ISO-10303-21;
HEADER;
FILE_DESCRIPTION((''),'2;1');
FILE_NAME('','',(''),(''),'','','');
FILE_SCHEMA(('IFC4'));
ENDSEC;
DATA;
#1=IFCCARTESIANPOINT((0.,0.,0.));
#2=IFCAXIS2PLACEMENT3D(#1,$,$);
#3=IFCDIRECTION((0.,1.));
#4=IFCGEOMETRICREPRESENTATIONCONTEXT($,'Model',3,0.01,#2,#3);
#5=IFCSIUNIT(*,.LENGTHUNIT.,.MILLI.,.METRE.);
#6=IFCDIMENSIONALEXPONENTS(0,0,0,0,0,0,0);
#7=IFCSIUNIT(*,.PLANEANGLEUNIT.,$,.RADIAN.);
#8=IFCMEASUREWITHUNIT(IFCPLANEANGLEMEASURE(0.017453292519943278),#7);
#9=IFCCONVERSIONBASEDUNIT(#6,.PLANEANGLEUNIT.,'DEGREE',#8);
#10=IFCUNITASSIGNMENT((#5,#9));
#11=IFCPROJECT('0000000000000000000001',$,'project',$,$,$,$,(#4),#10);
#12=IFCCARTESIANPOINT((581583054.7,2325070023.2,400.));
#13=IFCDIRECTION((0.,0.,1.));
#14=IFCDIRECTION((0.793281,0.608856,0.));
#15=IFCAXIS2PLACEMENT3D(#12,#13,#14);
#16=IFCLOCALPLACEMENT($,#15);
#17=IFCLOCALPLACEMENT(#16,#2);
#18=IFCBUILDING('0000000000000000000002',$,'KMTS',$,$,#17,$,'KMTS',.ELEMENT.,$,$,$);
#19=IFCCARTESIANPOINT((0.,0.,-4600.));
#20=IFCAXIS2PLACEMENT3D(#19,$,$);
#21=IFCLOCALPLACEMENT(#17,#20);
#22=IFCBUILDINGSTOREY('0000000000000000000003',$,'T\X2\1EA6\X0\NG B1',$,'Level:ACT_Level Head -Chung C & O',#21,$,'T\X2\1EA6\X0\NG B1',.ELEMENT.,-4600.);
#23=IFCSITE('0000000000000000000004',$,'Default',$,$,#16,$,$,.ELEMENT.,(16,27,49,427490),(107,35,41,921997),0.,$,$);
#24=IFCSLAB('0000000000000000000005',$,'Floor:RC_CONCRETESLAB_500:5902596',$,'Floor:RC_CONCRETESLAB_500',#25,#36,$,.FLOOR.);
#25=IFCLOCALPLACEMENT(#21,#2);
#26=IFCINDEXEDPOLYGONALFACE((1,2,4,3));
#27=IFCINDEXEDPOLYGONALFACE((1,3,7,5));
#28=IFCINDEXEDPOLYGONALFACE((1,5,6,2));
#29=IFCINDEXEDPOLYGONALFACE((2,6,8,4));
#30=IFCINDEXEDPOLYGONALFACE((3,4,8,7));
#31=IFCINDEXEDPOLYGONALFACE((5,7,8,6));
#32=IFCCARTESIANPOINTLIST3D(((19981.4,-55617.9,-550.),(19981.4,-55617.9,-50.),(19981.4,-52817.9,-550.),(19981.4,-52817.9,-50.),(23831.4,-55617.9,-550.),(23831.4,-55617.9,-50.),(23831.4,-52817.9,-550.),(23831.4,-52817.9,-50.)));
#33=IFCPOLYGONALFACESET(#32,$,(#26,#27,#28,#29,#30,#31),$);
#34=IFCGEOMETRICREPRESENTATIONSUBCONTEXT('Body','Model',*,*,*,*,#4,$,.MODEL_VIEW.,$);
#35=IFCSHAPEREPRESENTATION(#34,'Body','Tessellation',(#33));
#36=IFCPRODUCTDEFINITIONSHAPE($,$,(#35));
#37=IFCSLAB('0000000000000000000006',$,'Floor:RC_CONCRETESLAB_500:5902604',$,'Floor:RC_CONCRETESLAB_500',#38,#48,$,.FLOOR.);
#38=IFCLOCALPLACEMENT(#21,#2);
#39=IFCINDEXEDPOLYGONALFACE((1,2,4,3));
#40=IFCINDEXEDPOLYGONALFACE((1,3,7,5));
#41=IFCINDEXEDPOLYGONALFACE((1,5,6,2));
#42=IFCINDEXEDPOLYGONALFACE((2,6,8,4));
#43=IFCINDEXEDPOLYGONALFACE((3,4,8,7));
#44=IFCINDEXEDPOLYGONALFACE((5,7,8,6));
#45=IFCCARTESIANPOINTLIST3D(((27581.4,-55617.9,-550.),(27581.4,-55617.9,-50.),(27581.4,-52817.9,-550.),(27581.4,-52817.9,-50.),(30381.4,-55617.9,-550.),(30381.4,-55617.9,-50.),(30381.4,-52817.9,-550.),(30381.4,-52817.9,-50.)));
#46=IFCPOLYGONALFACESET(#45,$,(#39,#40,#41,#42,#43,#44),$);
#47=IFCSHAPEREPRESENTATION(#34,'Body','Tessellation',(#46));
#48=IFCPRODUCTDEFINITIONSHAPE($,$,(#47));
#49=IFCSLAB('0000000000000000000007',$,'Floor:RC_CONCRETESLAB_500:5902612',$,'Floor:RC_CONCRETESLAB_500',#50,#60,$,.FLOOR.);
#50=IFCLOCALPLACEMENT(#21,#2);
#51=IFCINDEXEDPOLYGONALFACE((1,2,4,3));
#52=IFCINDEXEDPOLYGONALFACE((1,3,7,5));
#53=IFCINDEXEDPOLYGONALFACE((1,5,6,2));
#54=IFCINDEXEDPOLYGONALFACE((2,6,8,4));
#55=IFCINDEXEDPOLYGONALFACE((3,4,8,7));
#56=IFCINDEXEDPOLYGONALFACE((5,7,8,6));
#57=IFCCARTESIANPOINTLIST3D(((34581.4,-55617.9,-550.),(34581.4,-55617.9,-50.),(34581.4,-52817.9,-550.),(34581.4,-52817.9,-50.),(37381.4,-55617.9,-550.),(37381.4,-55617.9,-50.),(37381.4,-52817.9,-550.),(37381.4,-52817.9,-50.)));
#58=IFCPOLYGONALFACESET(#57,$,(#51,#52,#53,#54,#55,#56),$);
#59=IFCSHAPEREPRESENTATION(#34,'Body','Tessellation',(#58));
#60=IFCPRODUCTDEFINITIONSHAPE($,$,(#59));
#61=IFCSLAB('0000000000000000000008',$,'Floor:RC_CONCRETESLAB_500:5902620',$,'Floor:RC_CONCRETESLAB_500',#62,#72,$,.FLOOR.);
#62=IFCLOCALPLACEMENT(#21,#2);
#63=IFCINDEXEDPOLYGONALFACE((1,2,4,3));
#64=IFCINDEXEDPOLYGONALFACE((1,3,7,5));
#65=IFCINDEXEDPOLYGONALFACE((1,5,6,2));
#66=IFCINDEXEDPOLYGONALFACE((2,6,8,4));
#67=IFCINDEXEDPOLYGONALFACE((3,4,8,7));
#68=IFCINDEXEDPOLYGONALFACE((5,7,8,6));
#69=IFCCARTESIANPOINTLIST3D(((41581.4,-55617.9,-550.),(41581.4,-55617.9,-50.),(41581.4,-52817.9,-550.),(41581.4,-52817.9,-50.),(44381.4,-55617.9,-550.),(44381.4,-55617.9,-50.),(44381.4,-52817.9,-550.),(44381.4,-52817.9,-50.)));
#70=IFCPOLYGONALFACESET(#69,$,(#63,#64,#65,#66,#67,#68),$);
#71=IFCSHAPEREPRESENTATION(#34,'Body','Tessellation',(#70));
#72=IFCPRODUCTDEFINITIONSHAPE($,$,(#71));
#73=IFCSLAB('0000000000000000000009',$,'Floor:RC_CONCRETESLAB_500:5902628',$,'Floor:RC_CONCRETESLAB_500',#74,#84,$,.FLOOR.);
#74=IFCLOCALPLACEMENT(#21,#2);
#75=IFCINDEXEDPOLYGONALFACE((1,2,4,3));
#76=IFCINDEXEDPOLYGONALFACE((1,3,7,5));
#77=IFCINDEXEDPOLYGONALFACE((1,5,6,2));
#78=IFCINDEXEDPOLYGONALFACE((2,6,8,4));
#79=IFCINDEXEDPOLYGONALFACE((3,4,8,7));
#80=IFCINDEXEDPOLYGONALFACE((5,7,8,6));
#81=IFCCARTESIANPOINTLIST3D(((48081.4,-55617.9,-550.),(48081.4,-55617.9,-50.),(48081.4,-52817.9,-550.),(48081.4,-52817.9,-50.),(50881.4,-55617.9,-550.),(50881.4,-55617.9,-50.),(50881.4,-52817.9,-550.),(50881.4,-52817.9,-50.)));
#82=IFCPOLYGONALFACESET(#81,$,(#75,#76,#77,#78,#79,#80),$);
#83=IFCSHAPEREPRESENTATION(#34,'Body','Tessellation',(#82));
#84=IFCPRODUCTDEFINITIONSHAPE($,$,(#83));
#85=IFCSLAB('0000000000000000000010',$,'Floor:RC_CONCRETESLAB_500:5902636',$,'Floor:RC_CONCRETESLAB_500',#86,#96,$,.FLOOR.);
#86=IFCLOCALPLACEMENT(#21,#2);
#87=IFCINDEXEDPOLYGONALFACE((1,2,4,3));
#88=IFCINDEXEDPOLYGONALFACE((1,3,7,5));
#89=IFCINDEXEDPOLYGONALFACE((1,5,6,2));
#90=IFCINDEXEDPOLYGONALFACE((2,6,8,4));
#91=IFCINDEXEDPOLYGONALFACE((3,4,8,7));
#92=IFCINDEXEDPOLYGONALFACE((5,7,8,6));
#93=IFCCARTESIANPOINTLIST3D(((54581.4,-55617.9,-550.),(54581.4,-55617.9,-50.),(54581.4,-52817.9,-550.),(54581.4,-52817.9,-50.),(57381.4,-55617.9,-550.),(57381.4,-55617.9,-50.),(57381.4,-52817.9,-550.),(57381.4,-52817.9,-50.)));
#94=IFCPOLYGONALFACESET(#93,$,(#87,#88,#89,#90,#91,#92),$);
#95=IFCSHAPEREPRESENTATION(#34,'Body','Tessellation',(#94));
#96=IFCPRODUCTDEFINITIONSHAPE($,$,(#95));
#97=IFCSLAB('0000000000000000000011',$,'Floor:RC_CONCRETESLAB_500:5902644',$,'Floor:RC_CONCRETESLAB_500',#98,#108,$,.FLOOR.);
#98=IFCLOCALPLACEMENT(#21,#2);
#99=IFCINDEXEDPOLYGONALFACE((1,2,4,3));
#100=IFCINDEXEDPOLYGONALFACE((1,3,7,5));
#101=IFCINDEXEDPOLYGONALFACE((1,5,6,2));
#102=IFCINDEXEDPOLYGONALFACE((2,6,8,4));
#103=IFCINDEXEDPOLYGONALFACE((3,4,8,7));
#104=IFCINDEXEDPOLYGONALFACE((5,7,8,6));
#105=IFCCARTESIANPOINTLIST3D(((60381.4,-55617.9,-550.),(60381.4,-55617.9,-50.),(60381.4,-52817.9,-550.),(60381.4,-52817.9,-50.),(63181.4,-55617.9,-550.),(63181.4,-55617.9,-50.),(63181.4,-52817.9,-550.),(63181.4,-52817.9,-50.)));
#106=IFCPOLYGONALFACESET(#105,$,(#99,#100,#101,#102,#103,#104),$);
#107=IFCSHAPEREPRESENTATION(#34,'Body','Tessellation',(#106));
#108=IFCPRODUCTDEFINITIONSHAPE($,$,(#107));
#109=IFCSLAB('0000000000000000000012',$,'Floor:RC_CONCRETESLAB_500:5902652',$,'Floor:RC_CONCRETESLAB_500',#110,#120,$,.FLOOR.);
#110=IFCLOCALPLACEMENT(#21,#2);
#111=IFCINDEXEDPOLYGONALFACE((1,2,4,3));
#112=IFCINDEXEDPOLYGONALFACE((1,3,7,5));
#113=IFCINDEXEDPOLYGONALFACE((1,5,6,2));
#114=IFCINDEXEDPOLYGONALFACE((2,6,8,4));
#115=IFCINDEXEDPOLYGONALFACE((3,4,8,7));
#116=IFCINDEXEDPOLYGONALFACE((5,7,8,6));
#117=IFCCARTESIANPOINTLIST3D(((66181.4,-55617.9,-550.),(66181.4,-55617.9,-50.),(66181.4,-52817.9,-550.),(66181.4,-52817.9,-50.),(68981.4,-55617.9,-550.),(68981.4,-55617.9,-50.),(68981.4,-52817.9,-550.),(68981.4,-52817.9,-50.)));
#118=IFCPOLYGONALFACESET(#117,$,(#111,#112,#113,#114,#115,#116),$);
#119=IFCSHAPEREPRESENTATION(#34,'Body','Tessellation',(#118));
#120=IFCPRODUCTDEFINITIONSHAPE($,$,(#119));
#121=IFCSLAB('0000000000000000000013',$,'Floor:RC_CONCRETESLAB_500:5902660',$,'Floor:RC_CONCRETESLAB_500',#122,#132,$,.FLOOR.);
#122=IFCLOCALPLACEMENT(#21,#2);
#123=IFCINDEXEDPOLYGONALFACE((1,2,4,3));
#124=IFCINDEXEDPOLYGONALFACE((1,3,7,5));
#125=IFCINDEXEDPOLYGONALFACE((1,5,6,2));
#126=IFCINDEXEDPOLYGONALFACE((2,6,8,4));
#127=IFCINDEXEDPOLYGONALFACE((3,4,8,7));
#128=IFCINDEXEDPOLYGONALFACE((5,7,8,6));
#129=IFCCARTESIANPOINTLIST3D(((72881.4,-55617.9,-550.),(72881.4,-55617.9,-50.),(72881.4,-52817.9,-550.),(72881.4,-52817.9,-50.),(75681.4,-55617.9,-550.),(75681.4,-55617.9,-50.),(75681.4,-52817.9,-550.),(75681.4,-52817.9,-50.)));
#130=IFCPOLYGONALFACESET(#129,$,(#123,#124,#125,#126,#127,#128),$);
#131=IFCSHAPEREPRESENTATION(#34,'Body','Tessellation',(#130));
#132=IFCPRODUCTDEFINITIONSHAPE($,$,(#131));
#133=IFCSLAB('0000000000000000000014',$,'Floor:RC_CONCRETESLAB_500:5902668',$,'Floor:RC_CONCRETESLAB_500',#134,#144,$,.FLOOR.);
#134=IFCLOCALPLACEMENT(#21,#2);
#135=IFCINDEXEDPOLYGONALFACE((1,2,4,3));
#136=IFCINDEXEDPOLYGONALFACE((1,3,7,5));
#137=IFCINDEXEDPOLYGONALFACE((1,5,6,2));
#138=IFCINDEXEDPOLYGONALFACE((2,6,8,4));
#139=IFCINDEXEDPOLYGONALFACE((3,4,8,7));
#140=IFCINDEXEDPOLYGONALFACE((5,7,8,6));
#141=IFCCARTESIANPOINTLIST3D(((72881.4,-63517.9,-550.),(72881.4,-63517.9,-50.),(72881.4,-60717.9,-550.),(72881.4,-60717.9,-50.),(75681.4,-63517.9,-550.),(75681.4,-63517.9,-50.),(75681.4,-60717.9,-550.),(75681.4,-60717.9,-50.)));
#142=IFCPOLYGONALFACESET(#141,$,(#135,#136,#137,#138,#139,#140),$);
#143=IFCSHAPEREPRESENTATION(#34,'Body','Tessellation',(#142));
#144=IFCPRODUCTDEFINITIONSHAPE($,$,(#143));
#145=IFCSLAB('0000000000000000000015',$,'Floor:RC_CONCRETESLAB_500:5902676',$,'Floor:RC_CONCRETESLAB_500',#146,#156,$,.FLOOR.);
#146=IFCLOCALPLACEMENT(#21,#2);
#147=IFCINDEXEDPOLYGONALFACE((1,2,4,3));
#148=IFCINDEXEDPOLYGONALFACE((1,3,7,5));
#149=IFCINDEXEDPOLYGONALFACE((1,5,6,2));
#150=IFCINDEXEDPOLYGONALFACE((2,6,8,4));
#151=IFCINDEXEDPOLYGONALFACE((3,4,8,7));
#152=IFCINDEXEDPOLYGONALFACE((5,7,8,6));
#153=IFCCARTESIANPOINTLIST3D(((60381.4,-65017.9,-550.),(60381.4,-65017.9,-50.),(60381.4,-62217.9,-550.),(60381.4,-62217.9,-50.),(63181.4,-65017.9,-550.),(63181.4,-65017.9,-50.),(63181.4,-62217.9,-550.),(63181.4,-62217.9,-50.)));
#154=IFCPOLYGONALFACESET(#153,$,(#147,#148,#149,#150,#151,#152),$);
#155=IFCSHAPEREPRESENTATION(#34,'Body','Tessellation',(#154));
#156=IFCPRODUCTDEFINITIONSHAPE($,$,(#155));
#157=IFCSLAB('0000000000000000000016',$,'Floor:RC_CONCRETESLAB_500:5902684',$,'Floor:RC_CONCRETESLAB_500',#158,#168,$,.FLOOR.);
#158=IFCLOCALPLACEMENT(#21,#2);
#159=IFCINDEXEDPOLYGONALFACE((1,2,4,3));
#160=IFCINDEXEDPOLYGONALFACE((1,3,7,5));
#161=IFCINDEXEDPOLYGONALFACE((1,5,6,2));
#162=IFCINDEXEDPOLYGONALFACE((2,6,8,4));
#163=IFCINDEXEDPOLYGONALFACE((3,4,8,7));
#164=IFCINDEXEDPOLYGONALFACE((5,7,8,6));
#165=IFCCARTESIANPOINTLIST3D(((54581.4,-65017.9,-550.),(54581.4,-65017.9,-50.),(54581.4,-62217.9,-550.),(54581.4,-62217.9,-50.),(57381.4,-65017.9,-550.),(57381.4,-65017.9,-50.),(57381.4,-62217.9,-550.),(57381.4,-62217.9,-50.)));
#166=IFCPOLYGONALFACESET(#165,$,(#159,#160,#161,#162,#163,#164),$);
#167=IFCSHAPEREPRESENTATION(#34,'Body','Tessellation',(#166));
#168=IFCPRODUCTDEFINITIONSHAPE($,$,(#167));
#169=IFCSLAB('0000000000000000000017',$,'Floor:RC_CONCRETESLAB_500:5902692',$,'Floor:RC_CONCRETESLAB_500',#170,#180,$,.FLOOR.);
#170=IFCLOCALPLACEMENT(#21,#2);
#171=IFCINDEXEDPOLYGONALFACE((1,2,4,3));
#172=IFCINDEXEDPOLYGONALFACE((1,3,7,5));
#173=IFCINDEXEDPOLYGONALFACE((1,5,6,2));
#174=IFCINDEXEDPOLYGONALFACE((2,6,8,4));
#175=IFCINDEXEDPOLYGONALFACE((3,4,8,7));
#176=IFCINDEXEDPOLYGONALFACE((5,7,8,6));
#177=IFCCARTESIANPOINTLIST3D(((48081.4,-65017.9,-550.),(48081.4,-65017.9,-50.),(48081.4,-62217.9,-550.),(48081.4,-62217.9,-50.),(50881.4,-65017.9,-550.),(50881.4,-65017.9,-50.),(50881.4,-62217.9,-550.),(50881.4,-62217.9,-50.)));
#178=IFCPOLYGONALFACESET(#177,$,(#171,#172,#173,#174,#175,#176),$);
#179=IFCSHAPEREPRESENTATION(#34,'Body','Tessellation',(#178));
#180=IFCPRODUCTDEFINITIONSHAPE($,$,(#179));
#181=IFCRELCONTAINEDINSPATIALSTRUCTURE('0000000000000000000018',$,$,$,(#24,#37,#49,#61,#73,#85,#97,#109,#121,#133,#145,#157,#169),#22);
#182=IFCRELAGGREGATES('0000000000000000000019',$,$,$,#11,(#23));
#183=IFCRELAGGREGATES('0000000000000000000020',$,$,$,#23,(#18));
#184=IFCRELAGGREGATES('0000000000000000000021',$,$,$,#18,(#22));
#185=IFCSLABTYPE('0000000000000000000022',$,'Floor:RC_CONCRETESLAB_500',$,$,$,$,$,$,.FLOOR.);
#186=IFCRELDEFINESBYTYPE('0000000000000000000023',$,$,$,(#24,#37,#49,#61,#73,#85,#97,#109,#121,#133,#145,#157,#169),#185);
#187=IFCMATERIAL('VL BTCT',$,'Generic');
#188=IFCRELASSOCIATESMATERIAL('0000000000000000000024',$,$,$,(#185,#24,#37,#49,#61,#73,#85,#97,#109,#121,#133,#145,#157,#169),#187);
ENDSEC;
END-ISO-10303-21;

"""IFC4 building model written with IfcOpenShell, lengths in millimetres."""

from ifc_helpers import new_model, entity, si_unit, converted_unit, direction, frame, origin, place, context, subcontext, project, spatial, indexed_curve, outline, extrude, material, type_object, element, save


model = new_model("IFC4")

# Units and contexts
model_context = context("Model", 3, precision=0.01, world=origin(), true_north=direction((0.0, 1.0)))
body_context = subcontext(model_context, "Body", "Model", "MODEL_VIEW")
ifc_project = project(units=[si_unit("LENGTHUNIT", "METRE", prefix="MILLI"), converted_unit("PLANEANGLEUNIT", "DEGREE", entity("IfcPlaneAngleMeasure", 0.017453292519943278), si_unit("PLANEANGLEUNIT", "RADIAN"), dimensions=[0, 0, 0, 0, 0, 0, 0])], contexts=[model_context])

# Site, building, storey
site_placement = place(None, frame((581583054.7, 2325070023.2, 400.0), z_axis=(0.0, 0.0, 1.0), x_axis=(0.793281, 0.608856, 0.0)))
site = spatial("IfcSite", under=ifc_project, at=site_placement, Name="Default", CompositionType="ELEMENT", RefLatitude=(16, 27, 49, 427490), RefLongitude=(107, 35, 41, 921997), RefElevation=0.0)
building_placement = place(site_placement, origin())
building = spatial("IfcBuilding", under=site, at=building_placement, Name="KMTS", LongName="KMTS", CompositionType="ELEMENT")
storey_placement = place(building_placement, frame((0.0, 0.0, -4600.0)))
storey = spatial("IfcBuildingStorey", under=building, at=storey_placement, Name="TẦNG B1", ObjectType="Level:ACT_Level Head -Chung C & O", LongName="TẦNG B1", CompositionType="ELEMENT", Elevation=-4600.0)

# Slabs
ifc_material = material(Name="VL BTCT", Category="Generic")
slab_type = type_object("IfcSlabType", Name="Floor:RC_CONCRETESLAB_500", PredefinedType="FLOOR", material=ifc_material)
slab_1_placement = place(storey_placement, origin())
element("IfcSlab", 1, at=slab_1_placement, inside=storey, type_object=slab_type, material=ifc_material, Name="Floor:RC_CONCRETESLAB_500:5902596", ObjectType="Floor:RC_CONCRETESLAB_500", PredefinedType="FLOOR", context=body_context, shape_type="SweptSolid", body=[
    extrude(outline(indexed_curve([(-1400.0, -1925.0), (1400.0, -1925.0), (1400.0, 1925.0), (-1400.0, 1925.0), (-1400.0, -1925.0)], self_intersect=False)), frame((21906.4, -54217.9, -50.0), z_axis=(0.0, 0.0, -1.0), x_axis=(0.0, 1.0, 0.0)), (0.0, 0.0, 1.0), 500.0),
])
slab_2_placement = place(storey_placement, origin())
element("IfcSlab", 2, at=slab_2_placement, inside=storey, type_object=slab_type, material=ifc_material, Name="Floor:RC_CONCRETESLAB_500:5902604", ObjectType="Floor:RC_CONCRETESLAB_500", PredefinedType="FLOOR", context=body_context, shape_type="SweptSolid", body=[
    extrude(outline(indexed_curve([(-1400.0, -1400.0), (1400.0, -1400.0), (1400.0, 1400.0), (-1400.0, 1400.0), (-1400.0, -1400.0)], self_intersect=False)), frame((28981.4, -54217.9, -50.0), z_axis=(0.0, 0.0, -1.0), x_axis=(0.0, 1.0, 0.0)), (0.0, 0.0, 1.0), 500.0),
])
slab_3_placement = place(storey_placement, origin())
element("IfcSlab", 3, at=slab_3_placement, inside=storey, type_object=slab_type, material=ifc_material, Name="Floor:RC_CONCRETESLAB_500:5902612", ObjectType="Floor:RC_CONCRETESLAB_500", PredefinedType="FLOOR", context=body_context, shape_type="SweptSolid", body=[
    extrude(outline(indexed_curve([(-1400.0, -1400.0), (1400.0, -1400.0), (1400.0, 1400.0), (-1400.0, 1400.0), (-1400.0, -1400.0)], self_intersect=False)), frame((35981.4, -54217.9, -50.0), z_axis=(0.0, 0.0, -1.0), x_axis=(0.0, 1.0, 0.0)), (0.0, 0.0, 1.0), 500.0),
])
slab_4_placement = place(storey_placement, origin())
element("IfcSlab", 4, at=slab_4_placement, inside=storey, type_object=slab_type, material=ifc_material, Name="Floor:RC_CONCRETESLAB_500:5902620", ObjectType="Floor:RC_CONCRETESLAB_500", PredefinedType="FLOOR", context=body_context, shape_type="SweptSolid", body=[
    extrude(outline(indexed_curve([(-1400.0, -1400.0), (1400.0, -1400.0), (1400.0, 1400.0), (-1400.0, 1400.0), (-1400.0, -1400.0)], self_intersect=False)), frame((42981.4, -54217.9, -50.0), z_axis=(0.0, 0.0, -1.0), x_axis=(0.0, 1.0, 0.0)), (0.0, 0.0, 1.0), 500.0),
])
slab_5_placement = place(storey_placement, origin())
element("IfcSlab", 5, at=slab_5_placement, inside=storey, type_object=slab_type, material=ifc_material, Name="Floor:RC_CONCRETESLAB_500:5902628", ObjectType="Floor:RC_CONCRETESLAB_500", PredefinedType="FLOOR", context=body_context, shape_type="SweptSolid", body=[
    extrude(outline(indexed_curve([(-1400.0, -1400.0), (1400.0, -1400.0), (1400.0, 1400.0), (-1400.0, 1400.0), (-1400.0, -1400.0)], self_intersect=False)), frame((49481.4, -54217.9, -50.0), z_axis=(0.0, 0.0, -1.0), x_axis=(0.0, 1.0, 0.0)), (0.0, 0.0, 1.0), 500.0),
])
slab_6_placement = place(storey_placement, origin())
element("IfcSlab", 6, at=slab_6_placement, inside=storey, type_object=slab_type, material=ifc_material, Name="Floor:RC_CONCRETESLAB_500:5902636", ObjectType="Floor:RC_CONCRETESLAB_500", PredefinedType="FLOOR", context=body_context, shape_type="SweptSolid", body=[
    extrude(outline(indexed_curve([(-1400.0, -1400.0), (1400.0, -1400.0), (1400.0, 1400.0), (-1400.0, 1400.0), (-1400.0, -1400.0)], self_intersect=False)), frame((55981.4, -54217.9, -50.0), z_axis=(0.0, 0.0, -1.0), x_axis=(0.0, 1.0, 0.0)), (0.0, 0.0, 1.0), 500.0),
])
slab_7_placement = place(storey_placement, origin())
element("IfcSlab", 7, at=slab_7_placement, inside=storey, type_object=slab_type, material=ifc_material, Name="Floor:RC_CONCRETESLAB_500:5902644", ObjectType="Floor:RC_CONCRETESLAB_500", PredefinedType="FLOOR", context=body_context, shape_type="SweptSolid", body=[
    extrude(outline(indexed_curve([(-1400.0, -1400.0), (1400.0, -1400.0), (1400.0, 1400.0), (-1400.0, 1400.0), (-1400.0, -1400.0)], self_intersect=False)), frame((61781.4, -54217.9, -50.0), z_axis=(0.0, 0.0, -1.0), x_axis=(0.0, 1.0, 0.0)), (0.0, 0.0, 1.0), 500.0),
])
slab_8_placement = place(storey_placement, origin())
element("IfcSlab", 8, at=slab_8_placement, inside=storey, type_object=slab_type, material=ifc_material, Name="Floor:RC_CONCRETESLAB_500:5902652", ObjectType="Floor:RC_CONCRETESLAB_500", PredefinedType="FLOOR", context=body_context, shape_type="SweptSolid", body=[
    extrude(outline(indexed_curve([(-1400.0, -1400.0), (1400.0, -1400.0), (1400.0, 1400.0), (-1400.0, 1400.0), (-1400.0, -1400.0)], self_intersect=False)), frame((67581.4, -54217.9, -50.0), z_axis=(0.0, 0.0, -1.0), x_axis=(0.0, 1.0, 0.0)), (0.0, 0.0, 1.0), 500.0),
])
slab_9_placement = place(storey_placement, origin())
element("IfcSlab", 9, at=slab_9_placement, inside=storey, type_object=slab_type, material=ifc_material, Name="Floor:RC_CONCRETESLAB_500:5902660", ObjectType="Floor:RC_CONCRETESLAB_500", PredefinedType="FLOOR", context=body_context, shape_type="SweptSolid", body=[
    extrude(outline(indexed_curve([(-1400.0, -1400.0), (1400.0, -1400.0), (1400.0, 1400.0), (-1400.0, 1400.0), (-1400.0, -1400.0)], self_intersect=False)), frame((74281.4, -54217.9, -50.0), z_axis=(0.0, 0.0, -1.0), x_axis=(0.0, 1.0, 0.0)), (0.0, 0.0, 1.0), 500.0),
])
slab_10_placement = place(storey_placement, origin())
element("IfcSlab", 10, at=slab_10_placement, inside=storey, type_object=slab_type, material=ifc_material, Name="Floor:RC_CONCRETESLAB_500:5902668", ObjectType="Floor:RC_CONCRETESLAB_500", PredefinedType="FLOOR", context=body_context, shape_type="SweptSolid", body=[
    extrude(outline(indexed_curve([(-1400.0, -1400.0), (1400.0, -1400.0), (1400.0, 1400.0), (-1400.0, 1400.0), (-1400.0, -1400.0)], self_intersect=False)), frame((74281.4, -62117.9, -50.0), z_axis=(0.0, 0.0, -1.0), x_axis=(0.0, 1.0, 0.0)), (0.0, 0.0, 1.0), 500.0),
])
slab_11_placement = place(storey_placement, origin())
element("IfcSlab", 11, at=slab_11_placement, inside=storey, type_object=slab_type, material=ifc_material, Name="Floor:RC_CONCRETESLAB_500:5902676", ObjectType="Floor:RC_CONCRETESLAB_500", PredefinedType="FLOOR", context=body_context, shape_type="SweptSolid", body=[
    extrude(outline(indexed_curve([(-1400.0, -1400.0), (1400.0, -1400.0), (1400.0, 1400.0), (-1400.0, 1400.0), (-1400.0, -1400.0)], self_intersect=False)), frame((61781.4, -63617.9, -50.0), z_axis=(0.0, 0.0, -1.0), x_axis=(0.0, 1.0, 0.0)), (0.0, 0.0, 1.0), 500.0),
])
slab_12_placement = place(storey_placement, origin())
element("IfcSlab", 12, at=slab_12_placement, inside=storey, type_object=slab_type, material=ifc_material, Name="Floor:RC_CONCRETESLAB_500:5902684", ObjectType="Floor:RC_CONCRETESLAB_500", PredefinedType="FLOOR", context=body_context, shape_type="SweptSolid", body=[
    extrude(outline(indexed_curve([(-1400.0, -1400.0), (1400.0, -1400.0), (1400.0, 1400.0), (-1400.0, 1400.0), (-1400.0, -1400.0)], self_intersect=False)), frame((55981.4, -63617.9, -50.0), z_axis=(0.0, 0.0, -1.0), x_axis=(0.0, 1.0, 0.0)), (0.0, 0.0, 1.0), 500.0),
])
slab_13_placement = place(storey_placement, origin())
element("IfcSlab", 13, at=slab_13_placement, inside=storey, type_object=slab_type, material=ifc_material, Name="Floor:RC_CONCRETESLAB_500:5902692", ObjectType="Floor:RC_CONCRETESLAB_500", PredefinedType="FLOOR", context=body_context, shape_type="SweptSolid", body=[
    extrude(outline(indexed_curve([(-1400.0, -1400.0), (1400.0, -1400.0), (1400.0, 1400.0), (-1400.0, 1400.0), (-1400.0, -1400.0)], self_intersect=False)), frame((49481.4, -63617.9, -50.0), z_axis=(0.0, 0.0, -1.0), x_axis=(0.0, 1.0, 0.0)), (0.0, 0.0, 1.0), 500.0),
])

save(model, "model.ifc")
